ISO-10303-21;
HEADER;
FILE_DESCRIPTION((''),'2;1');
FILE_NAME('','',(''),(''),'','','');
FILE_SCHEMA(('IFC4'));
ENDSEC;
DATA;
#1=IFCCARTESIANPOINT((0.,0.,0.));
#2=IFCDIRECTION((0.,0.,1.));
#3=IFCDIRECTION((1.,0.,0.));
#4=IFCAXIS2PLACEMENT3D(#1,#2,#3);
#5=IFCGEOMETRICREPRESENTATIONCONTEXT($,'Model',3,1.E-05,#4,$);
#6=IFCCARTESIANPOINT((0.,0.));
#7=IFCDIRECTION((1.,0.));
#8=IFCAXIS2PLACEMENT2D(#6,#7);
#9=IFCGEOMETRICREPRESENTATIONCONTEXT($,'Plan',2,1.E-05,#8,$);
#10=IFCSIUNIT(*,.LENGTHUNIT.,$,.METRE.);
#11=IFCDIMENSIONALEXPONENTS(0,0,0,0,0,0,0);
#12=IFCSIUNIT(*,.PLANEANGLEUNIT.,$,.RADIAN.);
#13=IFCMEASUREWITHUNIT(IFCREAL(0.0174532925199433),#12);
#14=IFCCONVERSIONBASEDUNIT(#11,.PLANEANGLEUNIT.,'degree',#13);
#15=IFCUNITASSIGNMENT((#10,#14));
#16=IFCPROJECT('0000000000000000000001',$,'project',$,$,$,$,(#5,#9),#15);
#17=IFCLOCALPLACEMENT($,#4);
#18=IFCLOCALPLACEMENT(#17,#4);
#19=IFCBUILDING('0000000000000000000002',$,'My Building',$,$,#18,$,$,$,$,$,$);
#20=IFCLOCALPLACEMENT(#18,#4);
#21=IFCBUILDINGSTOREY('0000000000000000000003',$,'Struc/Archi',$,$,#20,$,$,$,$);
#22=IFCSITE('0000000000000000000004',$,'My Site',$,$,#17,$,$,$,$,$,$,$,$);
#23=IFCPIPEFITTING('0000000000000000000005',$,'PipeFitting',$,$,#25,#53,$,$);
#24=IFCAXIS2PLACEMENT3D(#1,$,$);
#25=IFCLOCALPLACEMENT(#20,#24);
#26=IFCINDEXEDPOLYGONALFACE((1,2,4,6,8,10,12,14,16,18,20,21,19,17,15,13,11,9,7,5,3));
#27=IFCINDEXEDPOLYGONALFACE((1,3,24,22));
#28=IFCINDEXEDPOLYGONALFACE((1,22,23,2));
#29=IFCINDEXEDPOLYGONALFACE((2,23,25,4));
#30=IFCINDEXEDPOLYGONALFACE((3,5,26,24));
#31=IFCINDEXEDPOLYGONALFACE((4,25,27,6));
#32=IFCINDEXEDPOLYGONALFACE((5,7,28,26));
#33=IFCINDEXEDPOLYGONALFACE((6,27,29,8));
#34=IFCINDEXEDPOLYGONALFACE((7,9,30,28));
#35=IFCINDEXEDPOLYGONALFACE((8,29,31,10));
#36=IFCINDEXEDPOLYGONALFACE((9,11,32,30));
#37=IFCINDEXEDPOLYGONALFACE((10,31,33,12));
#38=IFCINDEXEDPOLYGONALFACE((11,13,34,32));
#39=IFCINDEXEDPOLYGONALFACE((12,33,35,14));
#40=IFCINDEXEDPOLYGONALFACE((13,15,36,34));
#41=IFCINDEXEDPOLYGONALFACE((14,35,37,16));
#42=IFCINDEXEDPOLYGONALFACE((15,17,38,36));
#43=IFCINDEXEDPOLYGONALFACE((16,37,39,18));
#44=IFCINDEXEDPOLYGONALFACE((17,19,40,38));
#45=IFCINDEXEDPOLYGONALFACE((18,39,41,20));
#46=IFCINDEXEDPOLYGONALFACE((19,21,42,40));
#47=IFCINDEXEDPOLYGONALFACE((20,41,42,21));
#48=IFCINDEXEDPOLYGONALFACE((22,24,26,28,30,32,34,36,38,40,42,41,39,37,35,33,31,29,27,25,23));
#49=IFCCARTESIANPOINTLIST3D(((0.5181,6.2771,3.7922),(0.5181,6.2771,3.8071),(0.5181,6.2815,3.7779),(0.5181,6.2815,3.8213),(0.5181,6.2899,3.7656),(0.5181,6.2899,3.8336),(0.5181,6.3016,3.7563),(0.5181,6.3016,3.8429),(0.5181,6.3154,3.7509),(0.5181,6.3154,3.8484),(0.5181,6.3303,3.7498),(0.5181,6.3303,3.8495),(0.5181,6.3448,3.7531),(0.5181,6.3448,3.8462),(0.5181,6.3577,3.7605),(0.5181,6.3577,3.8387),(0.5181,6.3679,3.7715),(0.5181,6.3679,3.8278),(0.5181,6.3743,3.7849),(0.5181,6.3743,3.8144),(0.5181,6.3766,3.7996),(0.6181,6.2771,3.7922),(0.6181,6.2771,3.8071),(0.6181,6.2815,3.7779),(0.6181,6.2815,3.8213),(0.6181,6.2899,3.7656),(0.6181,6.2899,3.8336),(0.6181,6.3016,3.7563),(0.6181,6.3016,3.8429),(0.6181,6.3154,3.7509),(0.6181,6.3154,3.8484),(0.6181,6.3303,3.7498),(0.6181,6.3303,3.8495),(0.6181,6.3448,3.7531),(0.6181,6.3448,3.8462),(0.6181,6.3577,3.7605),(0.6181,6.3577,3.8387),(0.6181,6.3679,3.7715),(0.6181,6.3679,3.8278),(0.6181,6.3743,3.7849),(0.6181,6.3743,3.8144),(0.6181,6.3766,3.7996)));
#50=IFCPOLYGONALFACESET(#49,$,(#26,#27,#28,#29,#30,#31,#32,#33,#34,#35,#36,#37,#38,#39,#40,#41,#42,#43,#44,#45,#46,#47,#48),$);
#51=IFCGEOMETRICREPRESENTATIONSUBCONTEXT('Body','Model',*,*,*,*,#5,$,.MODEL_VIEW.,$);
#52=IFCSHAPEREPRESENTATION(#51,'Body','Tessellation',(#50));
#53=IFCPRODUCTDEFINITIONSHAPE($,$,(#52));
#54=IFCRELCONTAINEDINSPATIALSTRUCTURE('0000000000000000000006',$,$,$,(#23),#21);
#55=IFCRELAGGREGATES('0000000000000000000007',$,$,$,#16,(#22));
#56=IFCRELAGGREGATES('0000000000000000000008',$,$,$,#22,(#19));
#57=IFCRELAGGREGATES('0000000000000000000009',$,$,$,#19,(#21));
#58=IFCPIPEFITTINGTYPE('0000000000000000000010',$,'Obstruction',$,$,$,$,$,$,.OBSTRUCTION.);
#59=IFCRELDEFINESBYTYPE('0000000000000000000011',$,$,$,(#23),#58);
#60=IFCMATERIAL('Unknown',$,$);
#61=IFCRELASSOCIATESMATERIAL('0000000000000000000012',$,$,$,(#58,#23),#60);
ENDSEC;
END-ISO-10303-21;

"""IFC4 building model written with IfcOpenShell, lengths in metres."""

from ifc_helpers import new_model, entity, si_unit, converted_unit, frame, origin_with_axes, origin_2d_with_axis, place, context, subcontext, project, spatial, circle, extrude, material, material_profile, profile_set, profile_usage, type_object, element, save


model = new_model("IFC4")

# Units and contexts
model_context = context("Model", 3, precision=1e-05, world=origin_with_axes())
plan_context = context("Plan", 2, precision=1e-05, world=origin_2d_with_axis())
body_context_1 = subcontext(model_context, "Body", "Model", "MODEL_VIEW")
ifc_project = project(units=[si_unit("LENGTHUNIT", "METRE"), converted_unit("PLANEANGLEUNIT", "degree", entity("IfcReal", 0.0174532925199433), si_unit("PLANEANGLEUNIT", "RADIAN"), dimensions=[0, 0, 0, 0, 0, 0, 0])], contexts=[model_context, plan_context])

# Site, building, storey
site_placement = place(None, origin_with_axes())
site = spatial("IfcSite", under=ifc_project, at=site_placement, Name="My Site")
building_placement = place(site_placement, origin_with_axes())
building = spatial("IfcBuilding", under=site, at=building_placement, Name="My Building")
storey_placement = place(building_placement, origin_with_axes())
storey = spatial("IfcBuildingStorey", under=building, at=storey_placement, Name="Struc/Archi")

# Shared definitions
ifc_material = material(Name="Unknown")

# Pipe fitting
ifc_material_profile_1 = material_profile(ifc_material, circle(Radius=0.05))
ifc_profile_set_1 = profile_set([ifc_material_profile_1])
ifc_profile_usage_1 = profile_usage(ifc_profile_set_1, cardinal=5)
pipe_fitting_type = type_object("IfcPipeFittingType", Name="Obstruction", PredefinedType="OBSTRUCTION", material=ifc_profile_set_1)
pipe_fitting_placement = place(storey_placement, frame((0.5181, 6.3266, 3.7996), z_axis=(1.0, 0.0, 0.0), x_axis=(0.0, 1.0, 0.0)))
element("IfcPipeFitting", 1, at=pipe_fitting_placement, inside=storey, type_object=pipe_fitting_type, material=ifc_profile_usage_1, Name="PipeFitting", context=body_context_1, shape_type="SweptSolid", body=[
    extrude(circle(Radius=0.05), origin_with_axes(), (0.0, 0.0, 1.0), 0.1),
])

save(model, "model.ifc")
